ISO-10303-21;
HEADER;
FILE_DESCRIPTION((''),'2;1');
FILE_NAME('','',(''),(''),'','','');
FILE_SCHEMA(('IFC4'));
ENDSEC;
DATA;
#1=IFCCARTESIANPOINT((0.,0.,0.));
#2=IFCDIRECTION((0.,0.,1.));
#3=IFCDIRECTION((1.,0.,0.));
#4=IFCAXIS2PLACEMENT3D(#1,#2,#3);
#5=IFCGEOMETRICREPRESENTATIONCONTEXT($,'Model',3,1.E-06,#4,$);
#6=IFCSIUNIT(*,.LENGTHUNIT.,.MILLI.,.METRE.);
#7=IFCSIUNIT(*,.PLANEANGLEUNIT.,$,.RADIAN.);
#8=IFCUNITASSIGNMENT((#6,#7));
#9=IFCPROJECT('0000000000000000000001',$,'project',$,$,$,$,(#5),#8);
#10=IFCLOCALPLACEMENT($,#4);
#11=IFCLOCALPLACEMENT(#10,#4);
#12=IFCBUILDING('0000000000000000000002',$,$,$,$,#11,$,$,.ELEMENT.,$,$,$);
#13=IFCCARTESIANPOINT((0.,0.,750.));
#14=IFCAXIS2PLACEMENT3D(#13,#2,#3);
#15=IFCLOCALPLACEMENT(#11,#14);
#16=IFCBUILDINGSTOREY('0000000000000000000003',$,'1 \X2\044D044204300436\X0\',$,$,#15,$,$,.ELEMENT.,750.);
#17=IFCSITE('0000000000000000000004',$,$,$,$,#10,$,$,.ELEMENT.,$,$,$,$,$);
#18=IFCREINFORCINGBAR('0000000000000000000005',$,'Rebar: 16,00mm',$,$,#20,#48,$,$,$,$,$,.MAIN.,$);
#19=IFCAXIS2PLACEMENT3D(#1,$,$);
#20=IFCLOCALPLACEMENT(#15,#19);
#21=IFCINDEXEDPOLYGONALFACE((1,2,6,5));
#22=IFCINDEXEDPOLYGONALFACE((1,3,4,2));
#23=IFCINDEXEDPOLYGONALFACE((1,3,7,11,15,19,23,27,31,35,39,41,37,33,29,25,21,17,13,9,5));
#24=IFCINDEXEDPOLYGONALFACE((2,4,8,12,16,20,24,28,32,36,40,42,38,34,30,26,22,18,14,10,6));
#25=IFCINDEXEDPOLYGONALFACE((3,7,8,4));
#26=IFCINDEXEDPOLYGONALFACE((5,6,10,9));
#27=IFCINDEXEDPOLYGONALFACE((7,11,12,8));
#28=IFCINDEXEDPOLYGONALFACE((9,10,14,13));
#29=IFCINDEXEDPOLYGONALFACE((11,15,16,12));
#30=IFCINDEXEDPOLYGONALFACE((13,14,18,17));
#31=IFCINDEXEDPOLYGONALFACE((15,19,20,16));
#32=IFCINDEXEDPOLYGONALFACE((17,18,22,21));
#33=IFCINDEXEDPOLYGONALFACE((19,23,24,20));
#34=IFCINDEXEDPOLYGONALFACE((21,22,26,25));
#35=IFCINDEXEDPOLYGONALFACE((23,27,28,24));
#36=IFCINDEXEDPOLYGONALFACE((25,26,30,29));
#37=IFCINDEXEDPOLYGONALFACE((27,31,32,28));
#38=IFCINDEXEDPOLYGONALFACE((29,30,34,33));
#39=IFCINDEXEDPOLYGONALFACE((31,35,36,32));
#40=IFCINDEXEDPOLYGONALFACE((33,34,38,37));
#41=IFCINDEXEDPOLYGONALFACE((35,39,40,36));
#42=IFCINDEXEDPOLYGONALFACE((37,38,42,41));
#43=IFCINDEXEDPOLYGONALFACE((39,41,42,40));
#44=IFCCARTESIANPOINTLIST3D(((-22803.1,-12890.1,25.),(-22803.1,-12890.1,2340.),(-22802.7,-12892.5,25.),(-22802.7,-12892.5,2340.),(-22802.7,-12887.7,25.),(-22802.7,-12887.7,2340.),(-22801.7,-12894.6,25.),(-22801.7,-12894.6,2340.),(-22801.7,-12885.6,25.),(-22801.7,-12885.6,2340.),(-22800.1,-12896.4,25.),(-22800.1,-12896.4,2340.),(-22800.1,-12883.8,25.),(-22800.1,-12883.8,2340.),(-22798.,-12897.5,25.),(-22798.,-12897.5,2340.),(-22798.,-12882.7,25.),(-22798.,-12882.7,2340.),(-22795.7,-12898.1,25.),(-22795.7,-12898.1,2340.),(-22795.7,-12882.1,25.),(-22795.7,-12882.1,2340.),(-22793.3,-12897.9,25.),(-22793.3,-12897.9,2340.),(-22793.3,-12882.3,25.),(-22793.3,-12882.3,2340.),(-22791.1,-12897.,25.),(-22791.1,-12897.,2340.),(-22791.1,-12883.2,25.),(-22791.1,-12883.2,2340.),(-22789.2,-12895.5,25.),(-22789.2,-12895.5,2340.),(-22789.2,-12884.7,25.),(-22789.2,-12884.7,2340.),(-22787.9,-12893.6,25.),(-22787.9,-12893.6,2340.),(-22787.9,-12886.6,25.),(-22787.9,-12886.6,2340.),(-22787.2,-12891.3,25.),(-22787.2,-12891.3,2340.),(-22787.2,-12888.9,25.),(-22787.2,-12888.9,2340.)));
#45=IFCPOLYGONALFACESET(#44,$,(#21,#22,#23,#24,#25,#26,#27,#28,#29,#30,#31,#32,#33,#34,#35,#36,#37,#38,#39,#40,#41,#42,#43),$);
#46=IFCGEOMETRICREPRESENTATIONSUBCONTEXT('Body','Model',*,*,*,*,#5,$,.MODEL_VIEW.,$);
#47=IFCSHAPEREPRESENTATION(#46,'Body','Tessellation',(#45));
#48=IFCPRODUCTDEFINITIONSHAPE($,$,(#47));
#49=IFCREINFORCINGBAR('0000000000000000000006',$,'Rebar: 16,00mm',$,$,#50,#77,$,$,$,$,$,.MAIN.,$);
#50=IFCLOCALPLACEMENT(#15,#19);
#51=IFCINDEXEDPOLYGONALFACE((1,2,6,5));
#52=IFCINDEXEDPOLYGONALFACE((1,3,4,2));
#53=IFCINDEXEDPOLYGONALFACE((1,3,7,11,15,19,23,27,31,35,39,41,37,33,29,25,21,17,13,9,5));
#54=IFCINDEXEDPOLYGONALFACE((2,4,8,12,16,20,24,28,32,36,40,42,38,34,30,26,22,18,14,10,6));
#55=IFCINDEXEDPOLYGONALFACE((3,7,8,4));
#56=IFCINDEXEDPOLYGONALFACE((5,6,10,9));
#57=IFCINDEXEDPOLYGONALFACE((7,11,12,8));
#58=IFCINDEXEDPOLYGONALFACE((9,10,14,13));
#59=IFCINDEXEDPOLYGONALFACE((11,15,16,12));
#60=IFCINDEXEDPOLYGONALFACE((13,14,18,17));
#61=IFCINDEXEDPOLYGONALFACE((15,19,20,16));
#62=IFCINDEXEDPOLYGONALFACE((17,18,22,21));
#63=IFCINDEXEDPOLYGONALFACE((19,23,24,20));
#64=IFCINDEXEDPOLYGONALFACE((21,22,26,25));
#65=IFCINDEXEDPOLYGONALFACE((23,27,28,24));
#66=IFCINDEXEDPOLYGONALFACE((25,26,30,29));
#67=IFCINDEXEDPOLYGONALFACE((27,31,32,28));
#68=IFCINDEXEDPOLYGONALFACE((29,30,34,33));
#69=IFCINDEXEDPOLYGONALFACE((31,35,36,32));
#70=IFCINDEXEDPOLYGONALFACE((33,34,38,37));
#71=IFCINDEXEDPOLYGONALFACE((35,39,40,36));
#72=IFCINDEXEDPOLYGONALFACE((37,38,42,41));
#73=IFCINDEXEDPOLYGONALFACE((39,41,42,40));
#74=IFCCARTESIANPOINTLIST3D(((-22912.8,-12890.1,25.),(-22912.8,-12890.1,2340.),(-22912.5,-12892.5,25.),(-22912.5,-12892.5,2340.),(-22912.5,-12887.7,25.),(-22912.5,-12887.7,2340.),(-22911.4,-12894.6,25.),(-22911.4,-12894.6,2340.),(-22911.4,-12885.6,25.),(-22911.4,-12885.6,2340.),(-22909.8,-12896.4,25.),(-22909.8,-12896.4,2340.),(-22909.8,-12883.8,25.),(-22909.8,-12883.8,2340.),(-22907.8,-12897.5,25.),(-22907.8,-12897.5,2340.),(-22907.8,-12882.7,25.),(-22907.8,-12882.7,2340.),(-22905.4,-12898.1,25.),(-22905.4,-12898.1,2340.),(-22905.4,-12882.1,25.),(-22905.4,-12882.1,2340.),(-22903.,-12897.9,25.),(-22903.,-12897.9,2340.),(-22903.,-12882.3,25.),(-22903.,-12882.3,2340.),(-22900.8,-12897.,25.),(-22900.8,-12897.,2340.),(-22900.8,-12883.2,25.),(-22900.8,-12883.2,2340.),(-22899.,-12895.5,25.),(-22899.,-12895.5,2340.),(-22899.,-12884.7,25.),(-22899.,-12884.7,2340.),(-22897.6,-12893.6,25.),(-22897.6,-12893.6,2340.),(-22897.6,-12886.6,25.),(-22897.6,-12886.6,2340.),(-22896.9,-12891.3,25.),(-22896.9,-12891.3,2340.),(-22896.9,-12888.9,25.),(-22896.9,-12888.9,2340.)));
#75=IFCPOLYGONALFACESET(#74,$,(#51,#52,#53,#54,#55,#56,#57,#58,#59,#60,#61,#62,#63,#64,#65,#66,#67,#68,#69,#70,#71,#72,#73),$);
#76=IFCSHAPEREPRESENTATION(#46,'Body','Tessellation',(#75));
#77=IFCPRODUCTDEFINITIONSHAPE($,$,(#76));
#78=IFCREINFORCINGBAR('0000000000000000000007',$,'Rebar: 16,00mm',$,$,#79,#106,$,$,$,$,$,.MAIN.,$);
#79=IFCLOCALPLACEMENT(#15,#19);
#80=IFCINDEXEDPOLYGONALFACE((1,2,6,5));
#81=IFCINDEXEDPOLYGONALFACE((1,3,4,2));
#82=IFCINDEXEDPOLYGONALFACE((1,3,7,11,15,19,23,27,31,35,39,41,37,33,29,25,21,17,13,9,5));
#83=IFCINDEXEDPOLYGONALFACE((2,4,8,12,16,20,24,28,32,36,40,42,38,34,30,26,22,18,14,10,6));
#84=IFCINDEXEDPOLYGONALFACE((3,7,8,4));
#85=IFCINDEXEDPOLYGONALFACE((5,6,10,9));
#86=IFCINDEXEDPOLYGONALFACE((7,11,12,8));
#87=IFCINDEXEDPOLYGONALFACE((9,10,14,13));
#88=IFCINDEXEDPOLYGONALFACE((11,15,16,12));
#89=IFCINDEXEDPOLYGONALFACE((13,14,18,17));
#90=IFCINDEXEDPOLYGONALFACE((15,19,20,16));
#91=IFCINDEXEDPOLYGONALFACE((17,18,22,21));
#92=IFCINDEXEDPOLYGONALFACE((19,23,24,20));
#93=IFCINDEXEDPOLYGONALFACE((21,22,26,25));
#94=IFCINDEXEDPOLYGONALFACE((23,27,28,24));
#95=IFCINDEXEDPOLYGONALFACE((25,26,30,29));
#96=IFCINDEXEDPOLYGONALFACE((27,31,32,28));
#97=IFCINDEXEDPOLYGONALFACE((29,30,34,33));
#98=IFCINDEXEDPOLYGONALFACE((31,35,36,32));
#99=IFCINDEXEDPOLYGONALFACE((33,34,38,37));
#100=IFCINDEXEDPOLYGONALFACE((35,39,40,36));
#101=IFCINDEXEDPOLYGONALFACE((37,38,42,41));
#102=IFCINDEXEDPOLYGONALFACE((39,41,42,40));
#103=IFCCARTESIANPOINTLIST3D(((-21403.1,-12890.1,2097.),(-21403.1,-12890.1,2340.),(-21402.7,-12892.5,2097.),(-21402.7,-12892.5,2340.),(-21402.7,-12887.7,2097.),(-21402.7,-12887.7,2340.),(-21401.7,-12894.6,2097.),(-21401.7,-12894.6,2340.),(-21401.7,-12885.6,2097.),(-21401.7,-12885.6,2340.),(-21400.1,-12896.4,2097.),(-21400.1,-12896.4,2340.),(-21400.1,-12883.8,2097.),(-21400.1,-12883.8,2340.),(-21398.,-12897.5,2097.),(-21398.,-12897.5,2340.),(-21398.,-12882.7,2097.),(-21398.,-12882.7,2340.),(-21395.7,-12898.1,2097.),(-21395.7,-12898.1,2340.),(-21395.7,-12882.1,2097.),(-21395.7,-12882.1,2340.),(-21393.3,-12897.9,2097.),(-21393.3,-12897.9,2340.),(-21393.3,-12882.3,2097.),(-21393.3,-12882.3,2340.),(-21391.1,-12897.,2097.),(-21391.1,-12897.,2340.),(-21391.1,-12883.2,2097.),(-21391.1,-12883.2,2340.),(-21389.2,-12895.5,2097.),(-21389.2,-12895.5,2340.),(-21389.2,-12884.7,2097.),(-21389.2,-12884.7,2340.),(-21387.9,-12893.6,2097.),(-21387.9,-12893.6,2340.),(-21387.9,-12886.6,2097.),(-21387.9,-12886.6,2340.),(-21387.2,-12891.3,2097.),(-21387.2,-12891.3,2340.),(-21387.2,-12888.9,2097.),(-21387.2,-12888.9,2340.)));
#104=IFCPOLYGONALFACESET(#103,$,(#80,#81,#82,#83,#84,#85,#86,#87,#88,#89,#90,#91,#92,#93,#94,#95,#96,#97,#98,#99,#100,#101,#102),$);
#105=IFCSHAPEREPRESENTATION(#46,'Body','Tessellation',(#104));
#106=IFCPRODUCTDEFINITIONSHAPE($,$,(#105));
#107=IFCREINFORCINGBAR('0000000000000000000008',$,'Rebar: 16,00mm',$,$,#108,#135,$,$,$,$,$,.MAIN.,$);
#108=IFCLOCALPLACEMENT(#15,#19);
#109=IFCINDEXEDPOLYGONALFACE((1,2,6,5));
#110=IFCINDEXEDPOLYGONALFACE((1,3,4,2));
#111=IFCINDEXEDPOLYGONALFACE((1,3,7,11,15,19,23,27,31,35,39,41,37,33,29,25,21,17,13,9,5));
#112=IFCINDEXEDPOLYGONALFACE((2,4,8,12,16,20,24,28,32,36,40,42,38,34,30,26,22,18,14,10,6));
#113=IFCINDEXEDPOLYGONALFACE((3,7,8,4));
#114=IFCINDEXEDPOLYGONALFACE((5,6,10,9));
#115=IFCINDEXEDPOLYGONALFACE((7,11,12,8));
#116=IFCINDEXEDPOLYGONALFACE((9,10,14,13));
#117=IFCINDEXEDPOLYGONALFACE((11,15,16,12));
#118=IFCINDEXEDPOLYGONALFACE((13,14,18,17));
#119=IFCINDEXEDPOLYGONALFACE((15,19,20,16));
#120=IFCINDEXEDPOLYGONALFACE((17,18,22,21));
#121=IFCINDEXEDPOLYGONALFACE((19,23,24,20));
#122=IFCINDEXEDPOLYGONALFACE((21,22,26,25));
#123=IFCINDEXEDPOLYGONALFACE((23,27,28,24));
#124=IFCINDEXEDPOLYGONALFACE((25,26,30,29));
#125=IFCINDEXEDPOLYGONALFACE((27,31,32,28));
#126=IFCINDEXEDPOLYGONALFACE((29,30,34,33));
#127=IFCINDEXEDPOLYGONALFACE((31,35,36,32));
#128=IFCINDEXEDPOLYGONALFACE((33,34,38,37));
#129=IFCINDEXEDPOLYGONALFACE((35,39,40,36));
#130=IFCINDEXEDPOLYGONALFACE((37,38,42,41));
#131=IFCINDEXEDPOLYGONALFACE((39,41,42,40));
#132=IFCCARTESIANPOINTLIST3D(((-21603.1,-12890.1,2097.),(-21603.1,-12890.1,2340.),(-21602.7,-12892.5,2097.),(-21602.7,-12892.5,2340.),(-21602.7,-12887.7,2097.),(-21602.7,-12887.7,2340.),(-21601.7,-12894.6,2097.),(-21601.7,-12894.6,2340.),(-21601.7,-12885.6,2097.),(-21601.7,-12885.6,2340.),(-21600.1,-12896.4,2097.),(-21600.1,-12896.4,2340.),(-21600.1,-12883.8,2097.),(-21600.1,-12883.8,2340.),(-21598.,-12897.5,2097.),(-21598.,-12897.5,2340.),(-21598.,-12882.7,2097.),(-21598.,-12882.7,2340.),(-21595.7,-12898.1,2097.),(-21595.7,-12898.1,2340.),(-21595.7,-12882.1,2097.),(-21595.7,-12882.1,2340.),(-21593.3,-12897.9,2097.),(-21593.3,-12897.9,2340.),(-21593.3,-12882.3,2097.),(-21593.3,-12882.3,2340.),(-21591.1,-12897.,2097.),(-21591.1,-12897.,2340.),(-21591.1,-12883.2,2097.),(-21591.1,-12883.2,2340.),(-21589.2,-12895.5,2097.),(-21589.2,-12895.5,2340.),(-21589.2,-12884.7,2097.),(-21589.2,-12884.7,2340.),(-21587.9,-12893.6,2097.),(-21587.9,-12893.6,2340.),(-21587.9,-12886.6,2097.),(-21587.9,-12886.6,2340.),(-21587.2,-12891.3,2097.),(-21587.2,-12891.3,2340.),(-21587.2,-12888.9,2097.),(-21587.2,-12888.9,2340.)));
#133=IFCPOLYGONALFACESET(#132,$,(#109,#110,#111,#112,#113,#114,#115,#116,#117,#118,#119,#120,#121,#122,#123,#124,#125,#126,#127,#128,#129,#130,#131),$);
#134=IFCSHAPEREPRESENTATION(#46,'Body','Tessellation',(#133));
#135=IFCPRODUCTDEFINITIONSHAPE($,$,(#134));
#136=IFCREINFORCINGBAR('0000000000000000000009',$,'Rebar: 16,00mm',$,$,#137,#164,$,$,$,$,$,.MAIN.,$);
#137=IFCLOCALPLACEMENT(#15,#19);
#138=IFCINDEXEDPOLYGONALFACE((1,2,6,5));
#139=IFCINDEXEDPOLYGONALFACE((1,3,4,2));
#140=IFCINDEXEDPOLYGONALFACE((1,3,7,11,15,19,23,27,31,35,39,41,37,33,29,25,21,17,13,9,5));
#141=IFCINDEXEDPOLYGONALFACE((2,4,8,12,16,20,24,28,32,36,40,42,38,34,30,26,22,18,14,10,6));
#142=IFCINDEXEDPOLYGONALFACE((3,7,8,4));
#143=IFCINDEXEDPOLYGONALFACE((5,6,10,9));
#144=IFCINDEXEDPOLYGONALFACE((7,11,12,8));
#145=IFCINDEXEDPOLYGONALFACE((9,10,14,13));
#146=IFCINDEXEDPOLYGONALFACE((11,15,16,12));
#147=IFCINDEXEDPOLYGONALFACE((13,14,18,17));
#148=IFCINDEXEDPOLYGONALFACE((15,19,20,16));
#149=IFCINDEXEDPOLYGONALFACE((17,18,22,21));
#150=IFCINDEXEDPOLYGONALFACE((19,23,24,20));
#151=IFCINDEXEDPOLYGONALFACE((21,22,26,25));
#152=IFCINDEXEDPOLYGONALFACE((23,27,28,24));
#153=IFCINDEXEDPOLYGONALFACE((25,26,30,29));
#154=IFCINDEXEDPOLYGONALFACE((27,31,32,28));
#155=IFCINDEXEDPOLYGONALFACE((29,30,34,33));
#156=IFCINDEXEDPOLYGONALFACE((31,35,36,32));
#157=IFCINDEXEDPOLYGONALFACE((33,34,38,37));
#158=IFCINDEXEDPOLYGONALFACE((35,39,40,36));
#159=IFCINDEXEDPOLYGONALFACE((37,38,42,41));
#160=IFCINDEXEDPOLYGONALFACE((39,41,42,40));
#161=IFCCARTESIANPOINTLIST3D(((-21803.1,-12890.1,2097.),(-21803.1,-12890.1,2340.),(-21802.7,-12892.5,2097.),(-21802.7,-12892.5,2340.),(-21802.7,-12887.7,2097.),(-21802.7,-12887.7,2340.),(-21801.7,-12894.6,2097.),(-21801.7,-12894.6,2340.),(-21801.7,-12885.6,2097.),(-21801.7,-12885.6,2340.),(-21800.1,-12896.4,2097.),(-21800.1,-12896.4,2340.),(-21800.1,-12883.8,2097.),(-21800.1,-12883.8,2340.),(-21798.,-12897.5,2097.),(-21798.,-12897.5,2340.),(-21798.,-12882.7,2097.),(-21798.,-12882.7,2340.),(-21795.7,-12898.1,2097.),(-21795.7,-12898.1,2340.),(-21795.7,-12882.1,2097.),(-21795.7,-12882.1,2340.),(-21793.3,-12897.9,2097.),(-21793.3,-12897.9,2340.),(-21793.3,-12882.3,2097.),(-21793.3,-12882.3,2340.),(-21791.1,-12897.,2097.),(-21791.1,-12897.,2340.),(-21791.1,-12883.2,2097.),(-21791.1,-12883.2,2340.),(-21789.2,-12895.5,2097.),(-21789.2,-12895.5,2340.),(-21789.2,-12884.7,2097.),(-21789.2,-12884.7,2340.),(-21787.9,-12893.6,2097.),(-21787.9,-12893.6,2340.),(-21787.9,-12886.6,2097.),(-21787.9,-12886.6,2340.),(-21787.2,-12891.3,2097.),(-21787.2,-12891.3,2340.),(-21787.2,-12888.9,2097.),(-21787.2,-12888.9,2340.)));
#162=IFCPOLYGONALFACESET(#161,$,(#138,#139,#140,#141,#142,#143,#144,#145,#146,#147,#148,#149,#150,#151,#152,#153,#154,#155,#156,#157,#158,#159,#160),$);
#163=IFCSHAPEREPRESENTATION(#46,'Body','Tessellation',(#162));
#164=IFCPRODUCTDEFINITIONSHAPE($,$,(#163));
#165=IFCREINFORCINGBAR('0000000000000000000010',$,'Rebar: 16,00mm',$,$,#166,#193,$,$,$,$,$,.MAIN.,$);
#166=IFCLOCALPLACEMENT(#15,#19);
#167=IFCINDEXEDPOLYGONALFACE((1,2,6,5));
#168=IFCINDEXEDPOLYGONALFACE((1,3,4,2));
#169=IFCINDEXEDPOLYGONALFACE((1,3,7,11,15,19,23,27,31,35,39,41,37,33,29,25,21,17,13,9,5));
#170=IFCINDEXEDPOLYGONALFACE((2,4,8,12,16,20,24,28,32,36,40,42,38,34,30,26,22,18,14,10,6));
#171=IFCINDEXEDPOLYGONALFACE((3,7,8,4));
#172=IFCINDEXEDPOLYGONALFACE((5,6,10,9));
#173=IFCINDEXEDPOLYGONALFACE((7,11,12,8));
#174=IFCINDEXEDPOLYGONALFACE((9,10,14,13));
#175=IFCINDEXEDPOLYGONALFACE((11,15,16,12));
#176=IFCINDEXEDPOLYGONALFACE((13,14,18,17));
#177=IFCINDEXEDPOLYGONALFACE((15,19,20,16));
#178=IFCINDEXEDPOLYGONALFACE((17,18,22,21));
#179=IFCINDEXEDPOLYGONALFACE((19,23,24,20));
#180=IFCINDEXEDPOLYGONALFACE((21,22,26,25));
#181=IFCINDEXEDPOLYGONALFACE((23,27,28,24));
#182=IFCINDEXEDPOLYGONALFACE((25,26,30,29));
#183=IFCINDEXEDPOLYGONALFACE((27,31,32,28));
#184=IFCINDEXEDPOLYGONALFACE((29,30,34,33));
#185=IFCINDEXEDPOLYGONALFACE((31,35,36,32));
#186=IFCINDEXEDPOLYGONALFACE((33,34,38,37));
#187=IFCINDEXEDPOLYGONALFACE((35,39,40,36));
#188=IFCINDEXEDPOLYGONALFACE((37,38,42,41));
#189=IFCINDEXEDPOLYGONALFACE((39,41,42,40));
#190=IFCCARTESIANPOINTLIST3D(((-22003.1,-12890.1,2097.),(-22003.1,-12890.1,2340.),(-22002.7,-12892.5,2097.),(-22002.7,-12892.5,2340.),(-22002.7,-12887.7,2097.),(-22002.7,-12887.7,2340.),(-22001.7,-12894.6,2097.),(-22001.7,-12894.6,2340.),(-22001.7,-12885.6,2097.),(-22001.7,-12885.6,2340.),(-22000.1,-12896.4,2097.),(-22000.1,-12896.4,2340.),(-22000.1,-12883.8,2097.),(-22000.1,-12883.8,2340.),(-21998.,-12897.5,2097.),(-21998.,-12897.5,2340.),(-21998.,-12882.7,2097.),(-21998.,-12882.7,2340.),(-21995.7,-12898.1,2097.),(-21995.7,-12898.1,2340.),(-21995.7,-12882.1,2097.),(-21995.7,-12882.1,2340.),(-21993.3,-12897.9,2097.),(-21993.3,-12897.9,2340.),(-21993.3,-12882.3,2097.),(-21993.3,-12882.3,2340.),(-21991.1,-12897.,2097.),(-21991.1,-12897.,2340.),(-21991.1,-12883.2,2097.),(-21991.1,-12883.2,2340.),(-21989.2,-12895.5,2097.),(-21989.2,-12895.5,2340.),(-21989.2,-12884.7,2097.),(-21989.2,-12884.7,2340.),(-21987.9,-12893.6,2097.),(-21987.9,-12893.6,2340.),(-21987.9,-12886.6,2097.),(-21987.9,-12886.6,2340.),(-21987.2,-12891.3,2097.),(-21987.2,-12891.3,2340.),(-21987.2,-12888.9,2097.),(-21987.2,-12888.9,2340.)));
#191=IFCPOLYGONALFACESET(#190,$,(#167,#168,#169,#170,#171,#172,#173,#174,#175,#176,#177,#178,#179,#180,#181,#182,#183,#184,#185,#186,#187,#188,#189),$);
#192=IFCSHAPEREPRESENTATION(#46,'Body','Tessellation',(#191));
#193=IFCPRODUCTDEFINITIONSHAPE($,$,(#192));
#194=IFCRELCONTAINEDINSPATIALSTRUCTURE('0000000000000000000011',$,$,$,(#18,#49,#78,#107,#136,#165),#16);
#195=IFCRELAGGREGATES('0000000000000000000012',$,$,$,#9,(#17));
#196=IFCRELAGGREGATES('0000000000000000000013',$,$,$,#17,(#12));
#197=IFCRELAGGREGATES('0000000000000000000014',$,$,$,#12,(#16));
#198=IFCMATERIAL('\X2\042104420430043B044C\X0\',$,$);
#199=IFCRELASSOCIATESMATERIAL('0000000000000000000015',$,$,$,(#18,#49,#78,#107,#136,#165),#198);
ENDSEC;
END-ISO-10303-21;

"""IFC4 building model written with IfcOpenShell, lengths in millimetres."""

from ifc_helpers import new_model, entity, si_unit, frame, origin_with_axes, place, context, subcontext, project, spatial, source, transform, mapped, material, element, save


model = new_model("IFC4")

# Units and contexts
model_context = context("Model", 3, precision=1e-06, world=origin_with_axes())
body_context = subcontext(model_context, "Body", "Model", "MODEL_VIEW")
ifc_project = project(units=[si_unit("LENGTHUNIT", "METRE", prefix="MILLI"), si_unit("PLANEANGLEUNIT", "RADIAN")], contexts=[model_context])

# Site, building, storey
site_placement = place(None, origin_with_axes())
site = spatial("IfcSite", under=ifc_project, at=site_placement, CompositionType="ELEMENT")
building_placement = place(site_placement, origin_with_axes())
building = spatial("IfcBuilding", under=site, at=building_placement, CompositionType="ELEMENT")
storey_placement = place(building_placement, frame((0.0, 0.0, 750.0), z_axis=(0.0, 0.0, 1.0), x_axis=(1.0, 0.0, 0.0)))
storey = spatial("IfcBuildingStorey", under=building, at=storey_placement, Name="1 этаж", CompositionType="ELEMENT", Elevation=750.0)

# Reinforcing bars
ifc_material = material(Name="Сталь")
shared_shape_1 = source(origin_with_axes(), body_context, "Body", "AdvancedSweptSolid", [
    entity("IfcSweptDiskSolid", entity("IfcIndexedPolyCurve", entity("IfcCartesianPointList3D", [[0.0, 0.0, 0.0], [2315.0, 0.0, 0.0]]), [entity("IfcLineIndex", [1, 2])]), 8.0),
])
reinforcing_bar_1_placement = place(storey_placement, origin_with_axes())
element("IfcReinforcingBar", 1, at=reinforcing_bar_1_placement, inside=storey, material=ifc_material, Name="Rebar: 16,00mm", PredefinedType="MAIN", context=body_context, shape_type="MappedRepresentation", body=[
    mapped(shared_shape_1, transform((-22795.1, -12890.1, 25.0), x_axis=(0.0, 0.0, 1.0), y_axis=(0.0, 1.0, 0.0), z_axis=(-1.0, 0.0, 0.0), scale=1.0)),
])
reinforcing_bar_2_placement = place(storey_placement, origin_with_axes())
element("IfcReinforcingBar", 2, at=reinforcing_bar_2_placement, inside=storey, material=ifc_material, Name="Rebar: 16,00mm", PredefinedType="MAIN", context=body_context, shape_type="MappedRepresentation", body=[
    mapped(shared_shape_1, transform((-22904.8, -12890.1, 25.0), x_axis=(0.0, 0.0, 1.0), y_axis=(0.0, 1.0, 0.0), z_axis=(-1.0, 0.0, 0.0), scale=1.0)),
])
shared_shape_2 = source(origin_with_axes(), body_context, "Body", "AdvancedSweptSolid", [
    entity("IfcSweptDiskSolid", entity("IfcIndexedPolyCurve", entity("IfcCartesianPointList3D", [[0.0, 0.0, 0.0], [243.0, 0.0, 0.0]]), [entity("IfcLineIndex", [1, 2])]), 8.0),
])
reinforcing_bar_3_placement = place(storey_placement, origin_with_axes())
element("IfcReinforcingBar", 3, at=reinforcing_bar_3_placement, inside=storey, material=ifc_material, Name="Rebar: 16,00mm", PredefinedType="MAIN", context=body_context, shape_type="MappedRepresentation", body=[
    mapped(shared_shape_2, transform((-21395.1, -12890.1, 2097.0), x_axis=(0.0, 0.0, 1.0), y_axis=(0.0, 1.0, 0.0), z_axis=(-1.0, 0.0, 0.0), scale=1.0)),
])
reinforcing_bar_4_placement = place(storey_placement, origin_with_axes())
element("IfcReinforcingBar", 4, at=reinforcing_bar_4_placement, inside=storey, material=ifc_material, Name="Rebar: 16,00mm", PredefinedType="MAIN", context=body_context, shape_type="MappedRepresentation", body=[
    mapped(shared_shape_2, transform((-21595.1, -12890.1, 2097.0), x_axis=(0.0, 0.0, 1.0), y_axis=(0.0, 1.0, 0.0), z_axis=(-1.0, 0.0, 0.0), scale=1.0)),
])
reinforcing_bar_5_placement = place(storey_placement, origin_with_axes())
element("IfcReinforcingBar", 5, at=reinforcing_bar_5_placement, inside=storey, material=ifc_material, Name="Rebar: 16,00mm", PredefinedType="MAIN", context=body_context, shape_type="MappedRepresentation", body=[
    mapped(shared_shape_2, transform((-21795.1, -12890.1, 2097.0), x_axis=(0.0, 0.0, 1.0), y_axis=(0.0, 1.0, 0.0), z_axis=(-1.0, 0.0, 0.0), scale=1.0)),
])
reinforcing_bar_6_placement = place(storey_placement, origin_with_axes())
element("IfcReinforcingBar", 6, at=reinforcing_bar_6_placement, inside=storey, material=ifc_material, Name="Rebar: 16,00mm", PredefinedType="MAIN", context=body_context, shape_type="MappedRepresentation", body=[
    mapped(shared_shape_2, transform((-21995.1, -12890.1, 2097.0), x_axis=(0.0, 0.0, 1.0), y_axis=(0.0, 1.0, 0.0), z_axis=(-1.0, 0.0, 0.0), scale=1.0)),
])

save(model, "model.ifc")
